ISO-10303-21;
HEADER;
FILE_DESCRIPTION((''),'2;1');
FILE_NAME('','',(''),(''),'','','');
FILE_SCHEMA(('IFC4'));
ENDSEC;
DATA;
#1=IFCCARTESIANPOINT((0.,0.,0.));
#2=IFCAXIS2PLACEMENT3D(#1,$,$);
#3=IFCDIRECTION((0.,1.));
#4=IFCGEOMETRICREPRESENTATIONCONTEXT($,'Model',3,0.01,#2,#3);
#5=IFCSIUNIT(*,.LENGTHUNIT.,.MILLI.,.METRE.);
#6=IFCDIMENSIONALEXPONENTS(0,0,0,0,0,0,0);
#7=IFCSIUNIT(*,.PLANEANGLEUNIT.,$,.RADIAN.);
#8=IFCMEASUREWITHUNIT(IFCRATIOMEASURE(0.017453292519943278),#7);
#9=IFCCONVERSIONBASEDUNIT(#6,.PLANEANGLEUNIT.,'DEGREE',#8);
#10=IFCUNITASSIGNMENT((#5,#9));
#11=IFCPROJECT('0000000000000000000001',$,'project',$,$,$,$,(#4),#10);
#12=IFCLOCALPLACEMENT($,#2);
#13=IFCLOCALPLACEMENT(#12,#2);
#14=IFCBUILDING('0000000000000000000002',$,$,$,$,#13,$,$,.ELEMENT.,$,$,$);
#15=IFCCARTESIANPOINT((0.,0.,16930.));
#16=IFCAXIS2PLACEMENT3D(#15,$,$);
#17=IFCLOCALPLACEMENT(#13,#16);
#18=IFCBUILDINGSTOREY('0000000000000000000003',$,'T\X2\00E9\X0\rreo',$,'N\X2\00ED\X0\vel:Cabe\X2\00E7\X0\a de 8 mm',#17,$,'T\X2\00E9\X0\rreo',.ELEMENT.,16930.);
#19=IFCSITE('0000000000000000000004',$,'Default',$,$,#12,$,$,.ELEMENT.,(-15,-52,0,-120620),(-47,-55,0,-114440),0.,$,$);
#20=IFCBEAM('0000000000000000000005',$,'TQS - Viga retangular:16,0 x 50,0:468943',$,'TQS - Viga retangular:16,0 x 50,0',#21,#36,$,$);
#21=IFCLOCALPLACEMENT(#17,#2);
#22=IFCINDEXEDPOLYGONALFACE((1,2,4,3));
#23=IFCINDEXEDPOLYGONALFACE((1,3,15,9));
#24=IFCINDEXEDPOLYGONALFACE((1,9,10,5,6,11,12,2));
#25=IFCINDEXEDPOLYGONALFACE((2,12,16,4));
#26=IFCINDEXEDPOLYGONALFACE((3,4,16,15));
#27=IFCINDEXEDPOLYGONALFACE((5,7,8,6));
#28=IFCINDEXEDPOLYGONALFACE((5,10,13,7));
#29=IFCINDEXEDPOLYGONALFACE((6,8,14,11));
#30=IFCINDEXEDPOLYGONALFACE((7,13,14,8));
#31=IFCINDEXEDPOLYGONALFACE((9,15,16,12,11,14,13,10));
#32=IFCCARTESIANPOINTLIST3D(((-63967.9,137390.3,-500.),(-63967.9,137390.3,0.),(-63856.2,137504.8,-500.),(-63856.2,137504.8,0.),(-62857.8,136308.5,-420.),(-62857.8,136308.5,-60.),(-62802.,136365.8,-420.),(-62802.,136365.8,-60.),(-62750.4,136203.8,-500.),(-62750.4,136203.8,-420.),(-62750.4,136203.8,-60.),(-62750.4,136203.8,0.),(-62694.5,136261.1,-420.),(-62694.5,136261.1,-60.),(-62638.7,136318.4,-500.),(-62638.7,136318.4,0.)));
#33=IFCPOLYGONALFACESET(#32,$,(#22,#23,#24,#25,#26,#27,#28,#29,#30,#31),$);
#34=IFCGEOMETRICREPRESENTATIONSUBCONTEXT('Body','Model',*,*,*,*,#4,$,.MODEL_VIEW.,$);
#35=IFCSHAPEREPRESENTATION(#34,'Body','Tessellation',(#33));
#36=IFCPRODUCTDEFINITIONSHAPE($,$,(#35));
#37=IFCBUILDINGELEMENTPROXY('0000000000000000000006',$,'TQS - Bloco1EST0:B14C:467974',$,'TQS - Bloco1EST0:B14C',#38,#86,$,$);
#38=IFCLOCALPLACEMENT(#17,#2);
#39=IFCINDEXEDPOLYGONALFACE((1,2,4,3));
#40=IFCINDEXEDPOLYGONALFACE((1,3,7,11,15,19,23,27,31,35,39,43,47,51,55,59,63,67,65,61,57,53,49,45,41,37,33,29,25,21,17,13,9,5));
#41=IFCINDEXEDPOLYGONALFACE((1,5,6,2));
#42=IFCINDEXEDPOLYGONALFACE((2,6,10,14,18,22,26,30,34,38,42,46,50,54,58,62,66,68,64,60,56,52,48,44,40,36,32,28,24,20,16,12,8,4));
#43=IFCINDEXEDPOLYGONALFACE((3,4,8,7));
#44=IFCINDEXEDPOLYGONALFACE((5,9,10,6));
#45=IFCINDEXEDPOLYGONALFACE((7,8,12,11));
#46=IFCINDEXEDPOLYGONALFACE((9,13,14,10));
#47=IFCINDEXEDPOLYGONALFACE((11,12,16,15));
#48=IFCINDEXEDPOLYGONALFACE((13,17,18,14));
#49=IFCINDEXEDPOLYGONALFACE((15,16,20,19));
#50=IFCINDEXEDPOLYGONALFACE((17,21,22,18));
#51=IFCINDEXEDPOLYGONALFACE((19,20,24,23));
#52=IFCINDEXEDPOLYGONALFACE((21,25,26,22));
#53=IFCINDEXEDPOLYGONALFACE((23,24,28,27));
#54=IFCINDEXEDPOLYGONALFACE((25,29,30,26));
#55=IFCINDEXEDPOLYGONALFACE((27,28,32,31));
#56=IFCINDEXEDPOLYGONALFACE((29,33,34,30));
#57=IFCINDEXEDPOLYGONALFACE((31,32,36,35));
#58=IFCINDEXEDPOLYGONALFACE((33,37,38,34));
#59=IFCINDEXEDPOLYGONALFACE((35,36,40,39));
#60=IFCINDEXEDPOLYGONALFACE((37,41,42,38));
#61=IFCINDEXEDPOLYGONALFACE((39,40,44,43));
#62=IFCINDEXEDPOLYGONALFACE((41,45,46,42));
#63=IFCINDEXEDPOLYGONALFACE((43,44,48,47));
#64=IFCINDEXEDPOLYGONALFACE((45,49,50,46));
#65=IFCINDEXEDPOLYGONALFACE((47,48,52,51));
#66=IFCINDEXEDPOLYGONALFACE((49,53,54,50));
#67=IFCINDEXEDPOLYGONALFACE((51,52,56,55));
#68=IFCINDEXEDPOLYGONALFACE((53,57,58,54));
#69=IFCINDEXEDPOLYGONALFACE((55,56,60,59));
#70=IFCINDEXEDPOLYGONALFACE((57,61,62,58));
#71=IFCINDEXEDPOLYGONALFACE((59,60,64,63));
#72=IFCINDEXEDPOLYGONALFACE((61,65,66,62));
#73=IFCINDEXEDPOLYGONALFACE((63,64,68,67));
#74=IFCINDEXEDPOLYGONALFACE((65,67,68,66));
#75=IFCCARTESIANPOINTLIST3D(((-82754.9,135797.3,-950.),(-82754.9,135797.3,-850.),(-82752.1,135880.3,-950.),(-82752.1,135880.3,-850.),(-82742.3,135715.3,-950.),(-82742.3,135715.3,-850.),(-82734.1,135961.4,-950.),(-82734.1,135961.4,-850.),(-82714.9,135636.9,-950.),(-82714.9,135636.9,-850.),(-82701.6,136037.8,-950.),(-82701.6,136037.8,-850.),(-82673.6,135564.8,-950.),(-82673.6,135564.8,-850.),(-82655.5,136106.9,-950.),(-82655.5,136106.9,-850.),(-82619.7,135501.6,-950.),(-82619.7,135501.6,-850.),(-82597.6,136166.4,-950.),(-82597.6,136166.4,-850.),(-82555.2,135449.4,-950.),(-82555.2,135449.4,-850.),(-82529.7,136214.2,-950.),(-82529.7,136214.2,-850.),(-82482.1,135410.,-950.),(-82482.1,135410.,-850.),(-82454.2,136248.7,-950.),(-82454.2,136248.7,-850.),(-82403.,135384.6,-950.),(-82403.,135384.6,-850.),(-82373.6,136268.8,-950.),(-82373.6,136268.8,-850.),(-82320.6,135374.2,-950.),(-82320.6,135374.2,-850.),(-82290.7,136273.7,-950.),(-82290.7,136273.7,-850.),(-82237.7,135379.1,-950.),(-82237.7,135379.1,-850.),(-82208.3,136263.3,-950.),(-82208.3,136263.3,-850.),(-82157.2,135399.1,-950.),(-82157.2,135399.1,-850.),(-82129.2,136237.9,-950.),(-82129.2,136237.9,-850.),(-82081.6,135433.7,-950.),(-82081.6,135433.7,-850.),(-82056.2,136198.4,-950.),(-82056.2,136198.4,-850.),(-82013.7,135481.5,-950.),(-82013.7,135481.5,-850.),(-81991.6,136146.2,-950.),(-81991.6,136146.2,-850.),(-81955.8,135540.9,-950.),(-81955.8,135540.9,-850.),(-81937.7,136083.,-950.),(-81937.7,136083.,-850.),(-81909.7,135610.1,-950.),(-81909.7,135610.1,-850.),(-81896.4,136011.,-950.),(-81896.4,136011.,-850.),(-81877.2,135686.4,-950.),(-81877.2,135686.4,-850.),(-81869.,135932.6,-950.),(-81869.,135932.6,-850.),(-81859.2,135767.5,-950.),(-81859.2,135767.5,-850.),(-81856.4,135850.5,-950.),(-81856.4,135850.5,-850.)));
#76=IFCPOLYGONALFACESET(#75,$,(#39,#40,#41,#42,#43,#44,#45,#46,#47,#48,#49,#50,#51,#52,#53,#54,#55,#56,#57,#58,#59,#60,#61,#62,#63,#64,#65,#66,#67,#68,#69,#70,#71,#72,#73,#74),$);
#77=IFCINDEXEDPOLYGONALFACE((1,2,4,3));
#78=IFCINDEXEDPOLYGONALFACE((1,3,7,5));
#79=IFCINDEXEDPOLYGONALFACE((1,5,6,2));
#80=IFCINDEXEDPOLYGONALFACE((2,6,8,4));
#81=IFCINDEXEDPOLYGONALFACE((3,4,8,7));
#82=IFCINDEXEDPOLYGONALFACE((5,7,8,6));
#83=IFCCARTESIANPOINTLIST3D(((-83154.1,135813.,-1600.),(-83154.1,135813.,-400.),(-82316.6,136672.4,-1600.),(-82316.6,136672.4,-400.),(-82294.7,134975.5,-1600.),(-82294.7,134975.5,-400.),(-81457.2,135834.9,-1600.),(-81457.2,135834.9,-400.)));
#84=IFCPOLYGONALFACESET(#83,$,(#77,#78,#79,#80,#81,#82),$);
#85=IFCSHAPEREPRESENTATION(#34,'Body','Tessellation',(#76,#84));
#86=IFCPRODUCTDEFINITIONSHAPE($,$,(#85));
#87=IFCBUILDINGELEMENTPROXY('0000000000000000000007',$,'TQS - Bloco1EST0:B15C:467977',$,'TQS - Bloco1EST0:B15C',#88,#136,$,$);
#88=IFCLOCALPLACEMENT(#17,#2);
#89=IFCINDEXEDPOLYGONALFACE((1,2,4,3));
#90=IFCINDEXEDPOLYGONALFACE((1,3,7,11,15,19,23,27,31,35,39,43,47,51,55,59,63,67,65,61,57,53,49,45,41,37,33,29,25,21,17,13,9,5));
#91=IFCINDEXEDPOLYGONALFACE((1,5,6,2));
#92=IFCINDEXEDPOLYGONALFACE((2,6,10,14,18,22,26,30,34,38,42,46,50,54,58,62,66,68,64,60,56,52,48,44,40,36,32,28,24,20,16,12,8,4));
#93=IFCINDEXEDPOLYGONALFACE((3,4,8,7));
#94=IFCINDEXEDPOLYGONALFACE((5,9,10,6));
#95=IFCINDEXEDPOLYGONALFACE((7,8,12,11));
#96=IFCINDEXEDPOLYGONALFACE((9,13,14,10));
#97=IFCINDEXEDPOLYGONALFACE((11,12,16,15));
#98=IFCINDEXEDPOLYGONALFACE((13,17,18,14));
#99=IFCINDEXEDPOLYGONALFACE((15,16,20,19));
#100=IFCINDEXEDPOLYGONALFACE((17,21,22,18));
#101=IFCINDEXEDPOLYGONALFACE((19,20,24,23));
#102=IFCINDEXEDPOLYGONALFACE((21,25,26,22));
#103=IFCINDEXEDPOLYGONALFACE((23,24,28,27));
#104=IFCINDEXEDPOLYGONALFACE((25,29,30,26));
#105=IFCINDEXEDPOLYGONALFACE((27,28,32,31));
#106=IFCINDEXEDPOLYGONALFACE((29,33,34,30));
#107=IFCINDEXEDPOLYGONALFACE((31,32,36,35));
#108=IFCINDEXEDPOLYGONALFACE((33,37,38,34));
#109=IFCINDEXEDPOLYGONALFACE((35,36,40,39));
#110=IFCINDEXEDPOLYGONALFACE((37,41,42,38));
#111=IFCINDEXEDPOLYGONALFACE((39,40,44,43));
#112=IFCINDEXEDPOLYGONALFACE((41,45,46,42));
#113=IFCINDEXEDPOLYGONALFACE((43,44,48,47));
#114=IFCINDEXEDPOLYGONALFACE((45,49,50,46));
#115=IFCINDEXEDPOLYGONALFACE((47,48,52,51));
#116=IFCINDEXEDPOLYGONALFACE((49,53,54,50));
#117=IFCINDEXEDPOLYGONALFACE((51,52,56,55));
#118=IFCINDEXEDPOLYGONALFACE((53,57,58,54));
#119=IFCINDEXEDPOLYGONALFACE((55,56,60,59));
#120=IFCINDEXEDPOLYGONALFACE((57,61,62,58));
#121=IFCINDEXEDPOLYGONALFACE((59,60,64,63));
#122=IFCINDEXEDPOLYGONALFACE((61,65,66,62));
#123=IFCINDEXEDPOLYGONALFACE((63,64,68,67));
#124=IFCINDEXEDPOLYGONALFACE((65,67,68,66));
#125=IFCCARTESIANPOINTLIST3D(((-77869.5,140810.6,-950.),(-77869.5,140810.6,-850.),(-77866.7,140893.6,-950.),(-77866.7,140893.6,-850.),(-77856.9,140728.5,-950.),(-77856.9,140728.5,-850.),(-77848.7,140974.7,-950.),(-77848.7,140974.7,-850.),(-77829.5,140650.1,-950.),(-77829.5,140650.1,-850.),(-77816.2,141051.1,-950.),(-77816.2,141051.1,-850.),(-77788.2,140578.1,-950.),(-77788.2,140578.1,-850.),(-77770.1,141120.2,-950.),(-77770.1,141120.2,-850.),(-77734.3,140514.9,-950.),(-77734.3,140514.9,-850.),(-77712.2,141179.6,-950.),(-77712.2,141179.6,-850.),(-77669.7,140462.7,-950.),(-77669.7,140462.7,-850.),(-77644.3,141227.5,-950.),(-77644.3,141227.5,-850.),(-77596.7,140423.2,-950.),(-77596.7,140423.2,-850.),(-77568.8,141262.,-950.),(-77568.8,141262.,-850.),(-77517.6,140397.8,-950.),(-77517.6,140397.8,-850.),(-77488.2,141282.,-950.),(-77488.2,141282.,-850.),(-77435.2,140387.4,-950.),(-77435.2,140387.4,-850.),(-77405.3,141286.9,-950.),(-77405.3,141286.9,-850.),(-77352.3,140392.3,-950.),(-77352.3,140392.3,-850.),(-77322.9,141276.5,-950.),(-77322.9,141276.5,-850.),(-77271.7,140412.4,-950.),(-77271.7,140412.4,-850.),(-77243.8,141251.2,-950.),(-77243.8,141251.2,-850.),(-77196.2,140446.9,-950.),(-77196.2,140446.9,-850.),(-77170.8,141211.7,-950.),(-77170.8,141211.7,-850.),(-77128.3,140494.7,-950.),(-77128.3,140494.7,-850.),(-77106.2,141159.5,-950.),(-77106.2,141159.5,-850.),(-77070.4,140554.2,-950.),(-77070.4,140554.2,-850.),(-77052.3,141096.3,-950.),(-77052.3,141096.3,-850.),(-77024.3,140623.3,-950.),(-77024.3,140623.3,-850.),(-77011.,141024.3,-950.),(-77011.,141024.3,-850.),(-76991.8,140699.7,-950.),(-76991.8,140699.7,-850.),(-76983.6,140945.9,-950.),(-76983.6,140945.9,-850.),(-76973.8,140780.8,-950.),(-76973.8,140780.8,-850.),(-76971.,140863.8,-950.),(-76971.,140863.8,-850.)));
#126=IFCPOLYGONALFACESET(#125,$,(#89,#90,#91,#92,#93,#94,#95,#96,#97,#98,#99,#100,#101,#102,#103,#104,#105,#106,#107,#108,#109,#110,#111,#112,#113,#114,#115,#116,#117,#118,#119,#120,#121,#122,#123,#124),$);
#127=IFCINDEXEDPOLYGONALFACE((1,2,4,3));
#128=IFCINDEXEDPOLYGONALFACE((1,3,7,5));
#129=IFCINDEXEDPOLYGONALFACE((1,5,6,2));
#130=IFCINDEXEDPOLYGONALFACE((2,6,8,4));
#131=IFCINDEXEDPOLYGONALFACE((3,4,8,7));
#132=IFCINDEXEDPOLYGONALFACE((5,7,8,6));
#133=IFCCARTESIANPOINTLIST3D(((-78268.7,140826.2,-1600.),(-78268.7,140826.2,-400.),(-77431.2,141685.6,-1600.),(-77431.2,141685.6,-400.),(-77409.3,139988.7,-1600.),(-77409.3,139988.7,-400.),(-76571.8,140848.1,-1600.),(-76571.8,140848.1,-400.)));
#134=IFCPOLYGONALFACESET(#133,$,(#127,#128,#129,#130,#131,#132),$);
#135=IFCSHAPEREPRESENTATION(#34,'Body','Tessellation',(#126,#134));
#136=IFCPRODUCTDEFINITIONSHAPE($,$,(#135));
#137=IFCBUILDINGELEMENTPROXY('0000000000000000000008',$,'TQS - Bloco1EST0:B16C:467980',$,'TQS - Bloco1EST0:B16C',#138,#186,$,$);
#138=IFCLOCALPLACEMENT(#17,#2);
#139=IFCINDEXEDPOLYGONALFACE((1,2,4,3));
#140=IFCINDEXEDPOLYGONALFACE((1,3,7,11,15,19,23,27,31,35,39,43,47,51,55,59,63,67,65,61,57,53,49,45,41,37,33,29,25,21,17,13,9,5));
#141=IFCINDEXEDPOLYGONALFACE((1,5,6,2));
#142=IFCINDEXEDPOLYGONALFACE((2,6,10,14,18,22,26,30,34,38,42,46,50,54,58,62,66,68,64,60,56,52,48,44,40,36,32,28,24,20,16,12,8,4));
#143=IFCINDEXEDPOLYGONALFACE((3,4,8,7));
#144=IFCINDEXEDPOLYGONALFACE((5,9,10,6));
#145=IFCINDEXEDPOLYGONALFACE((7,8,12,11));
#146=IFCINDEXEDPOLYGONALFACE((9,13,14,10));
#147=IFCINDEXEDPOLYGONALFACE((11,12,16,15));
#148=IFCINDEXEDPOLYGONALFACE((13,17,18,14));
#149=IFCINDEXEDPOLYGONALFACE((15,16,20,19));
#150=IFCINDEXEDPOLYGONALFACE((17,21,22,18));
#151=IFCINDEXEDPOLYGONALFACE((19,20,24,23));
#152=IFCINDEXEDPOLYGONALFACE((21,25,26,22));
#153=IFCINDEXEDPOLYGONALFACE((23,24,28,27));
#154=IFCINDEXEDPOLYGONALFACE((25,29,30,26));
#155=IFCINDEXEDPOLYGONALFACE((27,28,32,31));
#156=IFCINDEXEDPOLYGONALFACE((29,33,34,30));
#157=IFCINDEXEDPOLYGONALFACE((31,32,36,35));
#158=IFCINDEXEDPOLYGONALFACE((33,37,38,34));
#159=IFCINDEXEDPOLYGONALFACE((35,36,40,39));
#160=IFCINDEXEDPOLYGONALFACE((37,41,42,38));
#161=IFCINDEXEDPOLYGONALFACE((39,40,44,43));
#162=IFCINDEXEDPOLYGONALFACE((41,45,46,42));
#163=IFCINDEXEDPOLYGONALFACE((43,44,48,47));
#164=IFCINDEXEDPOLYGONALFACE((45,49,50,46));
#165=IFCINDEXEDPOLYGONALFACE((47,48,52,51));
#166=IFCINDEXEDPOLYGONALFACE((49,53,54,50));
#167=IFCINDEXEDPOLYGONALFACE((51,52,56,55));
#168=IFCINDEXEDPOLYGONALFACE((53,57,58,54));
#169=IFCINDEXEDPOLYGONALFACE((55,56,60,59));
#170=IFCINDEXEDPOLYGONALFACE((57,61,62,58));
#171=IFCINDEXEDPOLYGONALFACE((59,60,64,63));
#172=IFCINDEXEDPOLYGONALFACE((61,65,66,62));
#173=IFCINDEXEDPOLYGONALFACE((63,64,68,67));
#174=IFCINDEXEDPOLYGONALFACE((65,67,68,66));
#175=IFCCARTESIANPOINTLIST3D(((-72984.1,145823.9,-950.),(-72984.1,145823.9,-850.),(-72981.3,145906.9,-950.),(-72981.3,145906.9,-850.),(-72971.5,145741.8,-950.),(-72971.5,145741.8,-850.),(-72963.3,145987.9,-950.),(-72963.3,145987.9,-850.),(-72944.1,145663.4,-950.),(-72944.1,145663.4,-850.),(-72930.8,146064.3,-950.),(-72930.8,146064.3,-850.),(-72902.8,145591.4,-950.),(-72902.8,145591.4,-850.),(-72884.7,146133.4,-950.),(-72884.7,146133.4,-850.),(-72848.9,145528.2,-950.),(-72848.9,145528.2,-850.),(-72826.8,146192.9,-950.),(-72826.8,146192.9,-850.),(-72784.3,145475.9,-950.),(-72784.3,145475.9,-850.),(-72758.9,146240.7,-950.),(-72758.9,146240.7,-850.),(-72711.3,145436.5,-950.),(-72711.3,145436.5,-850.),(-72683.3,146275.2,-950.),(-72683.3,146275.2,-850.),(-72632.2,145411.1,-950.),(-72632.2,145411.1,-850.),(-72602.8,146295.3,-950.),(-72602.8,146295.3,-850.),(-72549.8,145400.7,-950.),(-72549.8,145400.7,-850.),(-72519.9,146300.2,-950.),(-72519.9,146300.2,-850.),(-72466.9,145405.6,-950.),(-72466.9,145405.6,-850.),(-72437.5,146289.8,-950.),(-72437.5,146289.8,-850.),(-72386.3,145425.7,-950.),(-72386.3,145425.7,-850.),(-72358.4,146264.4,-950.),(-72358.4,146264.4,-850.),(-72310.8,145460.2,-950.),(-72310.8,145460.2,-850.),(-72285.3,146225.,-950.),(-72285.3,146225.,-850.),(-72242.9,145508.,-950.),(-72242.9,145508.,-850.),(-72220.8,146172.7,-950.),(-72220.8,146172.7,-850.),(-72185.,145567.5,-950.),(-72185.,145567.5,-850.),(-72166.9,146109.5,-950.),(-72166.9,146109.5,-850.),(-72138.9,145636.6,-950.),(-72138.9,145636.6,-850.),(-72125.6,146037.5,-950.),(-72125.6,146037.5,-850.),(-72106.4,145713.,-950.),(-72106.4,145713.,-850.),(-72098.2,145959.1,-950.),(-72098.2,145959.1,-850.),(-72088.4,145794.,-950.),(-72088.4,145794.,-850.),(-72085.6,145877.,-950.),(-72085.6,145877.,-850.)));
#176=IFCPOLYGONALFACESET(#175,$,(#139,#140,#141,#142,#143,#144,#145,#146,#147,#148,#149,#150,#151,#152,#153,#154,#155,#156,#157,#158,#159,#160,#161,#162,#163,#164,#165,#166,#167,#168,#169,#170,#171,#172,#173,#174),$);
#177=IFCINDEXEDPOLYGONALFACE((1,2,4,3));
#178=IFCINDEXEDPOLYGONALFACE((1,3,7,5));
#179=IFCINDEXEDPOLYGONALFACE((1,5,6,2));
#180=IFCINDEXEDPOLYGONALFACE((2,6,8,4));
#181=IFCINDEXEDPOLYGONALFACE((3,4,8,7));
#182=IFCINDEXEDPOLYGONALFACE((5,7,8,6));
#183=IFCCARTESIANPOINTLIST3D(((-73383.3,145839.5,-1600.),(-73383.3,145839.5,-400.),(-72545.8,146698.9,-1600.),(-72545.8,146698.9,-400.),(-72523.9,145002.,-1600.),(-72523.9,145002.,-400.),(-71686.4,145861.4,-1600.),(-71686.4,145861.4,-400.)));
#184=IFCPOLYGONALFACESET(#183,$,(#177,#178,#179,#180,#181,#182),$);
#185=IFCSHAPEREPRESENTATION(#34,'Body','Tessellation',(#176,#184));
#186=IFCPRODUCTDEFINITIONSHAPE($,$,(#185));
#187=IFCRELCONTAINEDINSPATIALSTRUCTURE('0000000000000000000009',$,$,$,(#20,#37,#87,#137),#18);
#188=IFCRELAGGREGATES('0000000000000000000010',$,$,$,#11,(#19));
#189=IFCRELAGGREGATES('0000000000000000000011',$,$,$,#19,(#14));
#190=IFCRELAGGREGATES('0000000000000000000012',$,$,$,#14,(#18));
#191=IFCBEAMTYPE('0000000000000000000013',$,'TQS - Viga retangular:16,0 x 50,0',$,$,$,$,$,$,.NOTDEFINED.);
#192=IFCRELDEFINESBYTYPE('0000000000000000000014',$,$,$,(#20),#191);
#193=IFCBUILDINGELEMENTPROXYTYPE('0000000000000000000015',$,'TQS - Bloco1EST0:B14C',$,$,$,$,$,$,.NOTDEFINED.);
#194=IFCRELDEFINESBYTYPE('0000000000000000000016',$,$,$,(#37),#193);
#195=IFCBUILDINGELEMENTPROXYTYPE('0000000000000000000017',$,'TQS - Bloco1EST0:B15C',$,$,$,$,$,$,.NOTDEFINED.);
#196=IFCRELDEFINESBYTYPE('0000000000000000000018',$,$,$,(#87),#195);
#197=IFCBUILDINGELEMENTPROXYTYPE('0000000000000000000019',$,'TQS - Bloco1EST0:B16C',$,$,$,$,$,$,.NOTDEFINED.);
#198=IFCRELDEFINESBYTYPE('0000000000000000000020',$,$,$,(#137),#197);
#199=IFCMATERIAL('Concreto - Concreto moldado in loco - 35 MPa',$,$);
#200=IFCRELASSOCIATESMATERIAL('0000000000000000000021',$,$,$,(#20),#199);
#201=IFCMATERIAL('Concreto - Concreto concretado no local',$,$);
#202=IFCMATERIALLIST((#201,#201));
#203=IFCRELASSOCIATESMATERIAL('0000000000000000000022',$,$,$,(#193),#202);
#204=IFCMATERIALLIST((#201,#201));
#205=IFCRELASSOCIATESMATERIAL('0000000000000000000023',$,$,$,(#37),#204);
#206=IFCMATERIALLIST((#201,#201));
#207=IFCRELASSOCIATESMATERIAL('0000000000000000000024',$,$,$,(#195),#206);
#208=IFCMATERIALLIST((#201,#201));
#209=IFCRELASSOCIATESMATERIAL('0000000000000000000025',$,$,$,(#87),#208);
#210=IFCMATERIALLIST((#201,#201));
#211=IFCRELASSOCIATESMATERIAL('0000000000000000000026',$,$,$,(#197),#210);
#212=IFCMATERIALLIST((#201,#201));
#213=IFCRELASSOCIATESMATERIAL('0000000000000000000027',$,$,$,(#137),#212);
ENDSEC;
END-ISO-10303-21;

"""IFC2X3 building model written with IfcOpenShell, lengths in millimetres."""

from ifc_helpers import new_model, entity, si_unit, converted_unit, direction, frame, frame_2d, origin, origin_2d_with_axis, place, context, subcontext, project, spatial, polyline, rectangle, circle, extrude, boolean, clip, bounded_halfspace, source, transform, mapped, material, material_list, type_object, type_shapes, element, save


model = new_model("IFC2X3")

# Units and contexts
model_context = context("Model", 3, precision=0.01, world=origin(), true_north=direction((0.0, 1.0)))
body_context = subcontext(model_context, "Body", "Model", "MODEL_VIEW")
ifc_project = project(units=[si_unit("LENGTHUNIT", "METRE", prefix="MILLI"), converted_unit("PLANEANGLEUNIT", "DEGREE", entity("IfcRatioMeasure", 0.017453292519943278), si_unit("PLANEANGLEUNIT", "RADIAN"), dimensions=[0, 0, 0, 0, 0, 0, 0])], contexts=[model_context])

# Site, building, storey
site_placement = place(None, origin())
site = spatial("IfcSite", under=ifc_project, at=site_placement, Name="Default", CompositionType="ELEMENT", RefLatitude=(-15, -52, 0, -120620), RefLongitude=(-47, -55, 0, -114440), RefElevation=0.0)
building_placement = place(site_placement, origin())
building = spatial("IfcBuilding", under=site, at=building_placement, CompositionType="ELEMENT")
storey_placement = place(building_placement, frame((0.0, 0.0, 16930.0)))
storey = spatial("IfcBuildingStorey", under=building, at=storey_placement, Name="Térreo", ObjectType="Nível:Cabeça de 8 mm", LongName="Térreo", CompositionType="ELEMENT", Elevation=16930.0)

# Beam
ifc_material_1 = material(Name="Concreto - Concreto moldado in loco - 35 MPa")
beam_type_1 = type_object("IfcBeamType", Name="TQS - Viga retangular:16,0 x 50,0", PredefinedType="NOTDEFINED")
beam_1_placement = place(storey_placement, frame((-62694.5, 136261.1, 0.0), z_axis=(0.0, 0.0, 1.0), x_axis=(-0.71618, 0.697915, 0.0)))
element("IfcBeam", 1, at=beam_1_placement, inside=storey, type_object=beam_type_1, material=ifc_material_1, Name="TQS - Viga retangular:16,0 x 50,0:468943", ObjectType="TQS - Viga retangular:16,0 x 50,0", context=body_context, shape_type="SweptSolid", body=[
    boolean("DIFFERENCE", clip(extrude(rectangle(XDim=500.0, YDim=160.0, at=frame_2d((0.0, 0.0), x_axis=(1.0, 0.0))), frame((0.0, 0.0, -250.0), z_axis=(1.0, 0.0, 0.0), x_axis=(0.0, 0.0, -1.0)), (0.0, 0.0, 1.0), 1700.0), bounded_halfspace(frame((150.0, 0.0, -420.0), z_axis=(-1.0, 0.0, 0.0), x_axis=(0.0, 1.0, 0.0)), False, frame((0.0, 0.0, -250.0), z_axis=(1.0, 0.0, 0.0), x_axis=(0.0, 0.0, -1.0)), polyline([(170.0, 0.0), (-190.0, 0.0), (-190.0, 80.0), (-90.0, 80.0), (170.0, 80.0), (170.0, 0.0)]))), extrude(rectangle(XDim=360.0, YDim=80.0, at=frame_2d((0.0, 0.0), x_axis=(0.0, 1.0))), frame((0.0, 40.0, -240.0), z_axis=(-1.0, 0.0, 0.0), x_axis=(0.0, -1.0, 0.0)), (0.0, 0.0, -1.0), 150.0)),
])

# Building element proxies
ifc_material_2 = material(Name="Concreto - Concreto concretado no local")
ifc_material_list_1 = material_list([ifc_material_2, ifc_material_2])
ifc_material_list_2 = material_list([ifc_material_2, ifc_material_2])
building_element_proxy_type_1 = type_object("IfcBuildingElementProxyType", Name="TQS - Bloco1EST0:B14C", PredefinedType="NOTDEFINED", material=ifc_material_list_2)
shared_shape_1 = source(origin(), body_context, "Body", "SweptSolid", [
    extrude(circle(Radius=450.0, at=frame_2d((0.0, 0.0), x_axis=(1.0, 0.0))), frame((0.0, 0.0, -550.0)), (0.0, 0.0, 1.0), 100.0),
    extrude(rectangle(XDim=1200.0, YDim=1200.0, at=origin_2d_with_axis()), frame((0.0, 0.0, -1200.0), z_axis=(0.0, 0.0, 1.0), x_axis=(-1.0, 0.0, 0.0)), (0.0, 0.0, 1.0), 1200.0),
])
type_shapes(building_element_proxy_type_1, [shared_shape_1])
proxy_1_placement = place(storey_placement, frame((-82305.7, 135823.9, -400.0), z_axis=(0.0, 0.0, 1.0), x_axis=(0.697915, 0.71618, 0.0)))
element("IfcBuildingElementProxy", 2, at=proxy_1_placement, inside=storey, type_object=building_element_proxy_type_1, material=ifc_material_list_1, Name="TQS - Bloco1EST0:B14C:467974", ObjectType="TQS - Bloco1EST0:B14C", context=body_context, shape_type="MappedRepresentation", body=[
    mapped(shared_shape_1, transform((0.0, 0.0, 0.0), scale=1.0)),
])
ifc_material_list_3 = material_list([ifc_material_2, ifc_material_2])
ifc_material_list_4 = material_list([ifc_material_2, ifc_material_2])
building_element_proxy_type_2 = type_object("IfcBuildingElementProxyType", Name="TQS - Bloco1EST0:B15C", PredefinedType="NOTDEFINED", material=ifc_material_list_4)
shared_shape_2 = source(origin(), body_context, "Body", "SweptSolid", [
    extrude(circle(Radius=450.0, at=frame_2d((0.0, 0.0), x_axis=(1.0, 0.0))), frame((0.0, 0.0, -550.0)), (0.0, 0.0, 1.0), 100.0),
    extrude(rectangle(XDim=1200.0, YDim=1200.0, at=origin_2d_with_axis()), frame((0.0, 0.0, -1200.0), z_axis=(0.0, 0.0, 1.0), x_axis=(-1.0, 0.0, 0.0)), (0.0, 0.0, 1.0), 1200.0),
])
type_shapes(building_element_proxy_type_2, [shared_shape_2])
proxy_2_placement = place(storey_placement, frame((-77420.2, 140837.2, -400.0), z_axis=(0.0, 0.0, 1.0), x_axis=(0.697915, 0.71618, 0.0)))
element("IfcBuildingElementProxy", 3, at=proxy_2_placement, inside=storey, type_object=building_element_proxy_type_2, material=ifc_material_list_3, Name="TQS - Bloco1EST0:B15C:467977", ObjectType="TQS - Bloco1EST0:B15C", context=body_context, shape_type="MappedRepresentation", body=[
    mapped(shared_shape_2, transform((0.0, 0.0, 0.0), scale=1.0)),
])
ifc_material_list_5 = material_list([ifc_material_2, ifc_material_2])
ifc_material_list_6 = material_list([ifc_material_2, ifc_material_2])
building_element_proxy_type_3 = type_object("IfcBuildingElementProxyType", Name="TQS - Bloco1EST0:B16C", PredefinedType="NOTDEFINED", material=ifc_material_list_6)
shared_shape_3 = source(origin(), body_context, "Body", "SweptSolid", [
    extrude(circle(Radius=450.0, at=frame_2d((0.0, 0.0), x_axis=(1.0, 0.0))), frame((0.0, 0.0, -550.0)), (0.0, 0.0, 1.0), 100.0),
    extrude(rectangle(XDim=1200.0, YDim=1200.0, at=origin_2d_with_axis()), frame((0.0, 0.0, -1200.0), z_axis=(0.0, 0.0, 1.0), x_axis=(-1.0, 0.0, 0.0)), (0.0, 0.0, 1.0), 1200.0),
])
type_shapes(building_element_proxy_type_3, [shared_shape_3])
proxy_3_placement = place(storey_placement, frame((-72534.8, 145850.5, -400.0), z_axis=(0.0, 0.0, 1.0), x_axis=(0.697915, 0.71618, 0.0)))
element("IfcBuildingElementProxy", 4, at=proxy_3_placement, inside=storey, type_object=building_element_proxy_type_3, material=ifc_material_list_5, Name="TQS - Bloco1EST0:B16C:467980", ObjectType="TQS - Bloco1EST0:B16C", context=body_context, shape_type="MappedRepresentation", body=[
    mapped(shared_shape_3, transform((0.0, 0.0, 0.0), scale=1.0)),
])

save(model, "model.ifc")
